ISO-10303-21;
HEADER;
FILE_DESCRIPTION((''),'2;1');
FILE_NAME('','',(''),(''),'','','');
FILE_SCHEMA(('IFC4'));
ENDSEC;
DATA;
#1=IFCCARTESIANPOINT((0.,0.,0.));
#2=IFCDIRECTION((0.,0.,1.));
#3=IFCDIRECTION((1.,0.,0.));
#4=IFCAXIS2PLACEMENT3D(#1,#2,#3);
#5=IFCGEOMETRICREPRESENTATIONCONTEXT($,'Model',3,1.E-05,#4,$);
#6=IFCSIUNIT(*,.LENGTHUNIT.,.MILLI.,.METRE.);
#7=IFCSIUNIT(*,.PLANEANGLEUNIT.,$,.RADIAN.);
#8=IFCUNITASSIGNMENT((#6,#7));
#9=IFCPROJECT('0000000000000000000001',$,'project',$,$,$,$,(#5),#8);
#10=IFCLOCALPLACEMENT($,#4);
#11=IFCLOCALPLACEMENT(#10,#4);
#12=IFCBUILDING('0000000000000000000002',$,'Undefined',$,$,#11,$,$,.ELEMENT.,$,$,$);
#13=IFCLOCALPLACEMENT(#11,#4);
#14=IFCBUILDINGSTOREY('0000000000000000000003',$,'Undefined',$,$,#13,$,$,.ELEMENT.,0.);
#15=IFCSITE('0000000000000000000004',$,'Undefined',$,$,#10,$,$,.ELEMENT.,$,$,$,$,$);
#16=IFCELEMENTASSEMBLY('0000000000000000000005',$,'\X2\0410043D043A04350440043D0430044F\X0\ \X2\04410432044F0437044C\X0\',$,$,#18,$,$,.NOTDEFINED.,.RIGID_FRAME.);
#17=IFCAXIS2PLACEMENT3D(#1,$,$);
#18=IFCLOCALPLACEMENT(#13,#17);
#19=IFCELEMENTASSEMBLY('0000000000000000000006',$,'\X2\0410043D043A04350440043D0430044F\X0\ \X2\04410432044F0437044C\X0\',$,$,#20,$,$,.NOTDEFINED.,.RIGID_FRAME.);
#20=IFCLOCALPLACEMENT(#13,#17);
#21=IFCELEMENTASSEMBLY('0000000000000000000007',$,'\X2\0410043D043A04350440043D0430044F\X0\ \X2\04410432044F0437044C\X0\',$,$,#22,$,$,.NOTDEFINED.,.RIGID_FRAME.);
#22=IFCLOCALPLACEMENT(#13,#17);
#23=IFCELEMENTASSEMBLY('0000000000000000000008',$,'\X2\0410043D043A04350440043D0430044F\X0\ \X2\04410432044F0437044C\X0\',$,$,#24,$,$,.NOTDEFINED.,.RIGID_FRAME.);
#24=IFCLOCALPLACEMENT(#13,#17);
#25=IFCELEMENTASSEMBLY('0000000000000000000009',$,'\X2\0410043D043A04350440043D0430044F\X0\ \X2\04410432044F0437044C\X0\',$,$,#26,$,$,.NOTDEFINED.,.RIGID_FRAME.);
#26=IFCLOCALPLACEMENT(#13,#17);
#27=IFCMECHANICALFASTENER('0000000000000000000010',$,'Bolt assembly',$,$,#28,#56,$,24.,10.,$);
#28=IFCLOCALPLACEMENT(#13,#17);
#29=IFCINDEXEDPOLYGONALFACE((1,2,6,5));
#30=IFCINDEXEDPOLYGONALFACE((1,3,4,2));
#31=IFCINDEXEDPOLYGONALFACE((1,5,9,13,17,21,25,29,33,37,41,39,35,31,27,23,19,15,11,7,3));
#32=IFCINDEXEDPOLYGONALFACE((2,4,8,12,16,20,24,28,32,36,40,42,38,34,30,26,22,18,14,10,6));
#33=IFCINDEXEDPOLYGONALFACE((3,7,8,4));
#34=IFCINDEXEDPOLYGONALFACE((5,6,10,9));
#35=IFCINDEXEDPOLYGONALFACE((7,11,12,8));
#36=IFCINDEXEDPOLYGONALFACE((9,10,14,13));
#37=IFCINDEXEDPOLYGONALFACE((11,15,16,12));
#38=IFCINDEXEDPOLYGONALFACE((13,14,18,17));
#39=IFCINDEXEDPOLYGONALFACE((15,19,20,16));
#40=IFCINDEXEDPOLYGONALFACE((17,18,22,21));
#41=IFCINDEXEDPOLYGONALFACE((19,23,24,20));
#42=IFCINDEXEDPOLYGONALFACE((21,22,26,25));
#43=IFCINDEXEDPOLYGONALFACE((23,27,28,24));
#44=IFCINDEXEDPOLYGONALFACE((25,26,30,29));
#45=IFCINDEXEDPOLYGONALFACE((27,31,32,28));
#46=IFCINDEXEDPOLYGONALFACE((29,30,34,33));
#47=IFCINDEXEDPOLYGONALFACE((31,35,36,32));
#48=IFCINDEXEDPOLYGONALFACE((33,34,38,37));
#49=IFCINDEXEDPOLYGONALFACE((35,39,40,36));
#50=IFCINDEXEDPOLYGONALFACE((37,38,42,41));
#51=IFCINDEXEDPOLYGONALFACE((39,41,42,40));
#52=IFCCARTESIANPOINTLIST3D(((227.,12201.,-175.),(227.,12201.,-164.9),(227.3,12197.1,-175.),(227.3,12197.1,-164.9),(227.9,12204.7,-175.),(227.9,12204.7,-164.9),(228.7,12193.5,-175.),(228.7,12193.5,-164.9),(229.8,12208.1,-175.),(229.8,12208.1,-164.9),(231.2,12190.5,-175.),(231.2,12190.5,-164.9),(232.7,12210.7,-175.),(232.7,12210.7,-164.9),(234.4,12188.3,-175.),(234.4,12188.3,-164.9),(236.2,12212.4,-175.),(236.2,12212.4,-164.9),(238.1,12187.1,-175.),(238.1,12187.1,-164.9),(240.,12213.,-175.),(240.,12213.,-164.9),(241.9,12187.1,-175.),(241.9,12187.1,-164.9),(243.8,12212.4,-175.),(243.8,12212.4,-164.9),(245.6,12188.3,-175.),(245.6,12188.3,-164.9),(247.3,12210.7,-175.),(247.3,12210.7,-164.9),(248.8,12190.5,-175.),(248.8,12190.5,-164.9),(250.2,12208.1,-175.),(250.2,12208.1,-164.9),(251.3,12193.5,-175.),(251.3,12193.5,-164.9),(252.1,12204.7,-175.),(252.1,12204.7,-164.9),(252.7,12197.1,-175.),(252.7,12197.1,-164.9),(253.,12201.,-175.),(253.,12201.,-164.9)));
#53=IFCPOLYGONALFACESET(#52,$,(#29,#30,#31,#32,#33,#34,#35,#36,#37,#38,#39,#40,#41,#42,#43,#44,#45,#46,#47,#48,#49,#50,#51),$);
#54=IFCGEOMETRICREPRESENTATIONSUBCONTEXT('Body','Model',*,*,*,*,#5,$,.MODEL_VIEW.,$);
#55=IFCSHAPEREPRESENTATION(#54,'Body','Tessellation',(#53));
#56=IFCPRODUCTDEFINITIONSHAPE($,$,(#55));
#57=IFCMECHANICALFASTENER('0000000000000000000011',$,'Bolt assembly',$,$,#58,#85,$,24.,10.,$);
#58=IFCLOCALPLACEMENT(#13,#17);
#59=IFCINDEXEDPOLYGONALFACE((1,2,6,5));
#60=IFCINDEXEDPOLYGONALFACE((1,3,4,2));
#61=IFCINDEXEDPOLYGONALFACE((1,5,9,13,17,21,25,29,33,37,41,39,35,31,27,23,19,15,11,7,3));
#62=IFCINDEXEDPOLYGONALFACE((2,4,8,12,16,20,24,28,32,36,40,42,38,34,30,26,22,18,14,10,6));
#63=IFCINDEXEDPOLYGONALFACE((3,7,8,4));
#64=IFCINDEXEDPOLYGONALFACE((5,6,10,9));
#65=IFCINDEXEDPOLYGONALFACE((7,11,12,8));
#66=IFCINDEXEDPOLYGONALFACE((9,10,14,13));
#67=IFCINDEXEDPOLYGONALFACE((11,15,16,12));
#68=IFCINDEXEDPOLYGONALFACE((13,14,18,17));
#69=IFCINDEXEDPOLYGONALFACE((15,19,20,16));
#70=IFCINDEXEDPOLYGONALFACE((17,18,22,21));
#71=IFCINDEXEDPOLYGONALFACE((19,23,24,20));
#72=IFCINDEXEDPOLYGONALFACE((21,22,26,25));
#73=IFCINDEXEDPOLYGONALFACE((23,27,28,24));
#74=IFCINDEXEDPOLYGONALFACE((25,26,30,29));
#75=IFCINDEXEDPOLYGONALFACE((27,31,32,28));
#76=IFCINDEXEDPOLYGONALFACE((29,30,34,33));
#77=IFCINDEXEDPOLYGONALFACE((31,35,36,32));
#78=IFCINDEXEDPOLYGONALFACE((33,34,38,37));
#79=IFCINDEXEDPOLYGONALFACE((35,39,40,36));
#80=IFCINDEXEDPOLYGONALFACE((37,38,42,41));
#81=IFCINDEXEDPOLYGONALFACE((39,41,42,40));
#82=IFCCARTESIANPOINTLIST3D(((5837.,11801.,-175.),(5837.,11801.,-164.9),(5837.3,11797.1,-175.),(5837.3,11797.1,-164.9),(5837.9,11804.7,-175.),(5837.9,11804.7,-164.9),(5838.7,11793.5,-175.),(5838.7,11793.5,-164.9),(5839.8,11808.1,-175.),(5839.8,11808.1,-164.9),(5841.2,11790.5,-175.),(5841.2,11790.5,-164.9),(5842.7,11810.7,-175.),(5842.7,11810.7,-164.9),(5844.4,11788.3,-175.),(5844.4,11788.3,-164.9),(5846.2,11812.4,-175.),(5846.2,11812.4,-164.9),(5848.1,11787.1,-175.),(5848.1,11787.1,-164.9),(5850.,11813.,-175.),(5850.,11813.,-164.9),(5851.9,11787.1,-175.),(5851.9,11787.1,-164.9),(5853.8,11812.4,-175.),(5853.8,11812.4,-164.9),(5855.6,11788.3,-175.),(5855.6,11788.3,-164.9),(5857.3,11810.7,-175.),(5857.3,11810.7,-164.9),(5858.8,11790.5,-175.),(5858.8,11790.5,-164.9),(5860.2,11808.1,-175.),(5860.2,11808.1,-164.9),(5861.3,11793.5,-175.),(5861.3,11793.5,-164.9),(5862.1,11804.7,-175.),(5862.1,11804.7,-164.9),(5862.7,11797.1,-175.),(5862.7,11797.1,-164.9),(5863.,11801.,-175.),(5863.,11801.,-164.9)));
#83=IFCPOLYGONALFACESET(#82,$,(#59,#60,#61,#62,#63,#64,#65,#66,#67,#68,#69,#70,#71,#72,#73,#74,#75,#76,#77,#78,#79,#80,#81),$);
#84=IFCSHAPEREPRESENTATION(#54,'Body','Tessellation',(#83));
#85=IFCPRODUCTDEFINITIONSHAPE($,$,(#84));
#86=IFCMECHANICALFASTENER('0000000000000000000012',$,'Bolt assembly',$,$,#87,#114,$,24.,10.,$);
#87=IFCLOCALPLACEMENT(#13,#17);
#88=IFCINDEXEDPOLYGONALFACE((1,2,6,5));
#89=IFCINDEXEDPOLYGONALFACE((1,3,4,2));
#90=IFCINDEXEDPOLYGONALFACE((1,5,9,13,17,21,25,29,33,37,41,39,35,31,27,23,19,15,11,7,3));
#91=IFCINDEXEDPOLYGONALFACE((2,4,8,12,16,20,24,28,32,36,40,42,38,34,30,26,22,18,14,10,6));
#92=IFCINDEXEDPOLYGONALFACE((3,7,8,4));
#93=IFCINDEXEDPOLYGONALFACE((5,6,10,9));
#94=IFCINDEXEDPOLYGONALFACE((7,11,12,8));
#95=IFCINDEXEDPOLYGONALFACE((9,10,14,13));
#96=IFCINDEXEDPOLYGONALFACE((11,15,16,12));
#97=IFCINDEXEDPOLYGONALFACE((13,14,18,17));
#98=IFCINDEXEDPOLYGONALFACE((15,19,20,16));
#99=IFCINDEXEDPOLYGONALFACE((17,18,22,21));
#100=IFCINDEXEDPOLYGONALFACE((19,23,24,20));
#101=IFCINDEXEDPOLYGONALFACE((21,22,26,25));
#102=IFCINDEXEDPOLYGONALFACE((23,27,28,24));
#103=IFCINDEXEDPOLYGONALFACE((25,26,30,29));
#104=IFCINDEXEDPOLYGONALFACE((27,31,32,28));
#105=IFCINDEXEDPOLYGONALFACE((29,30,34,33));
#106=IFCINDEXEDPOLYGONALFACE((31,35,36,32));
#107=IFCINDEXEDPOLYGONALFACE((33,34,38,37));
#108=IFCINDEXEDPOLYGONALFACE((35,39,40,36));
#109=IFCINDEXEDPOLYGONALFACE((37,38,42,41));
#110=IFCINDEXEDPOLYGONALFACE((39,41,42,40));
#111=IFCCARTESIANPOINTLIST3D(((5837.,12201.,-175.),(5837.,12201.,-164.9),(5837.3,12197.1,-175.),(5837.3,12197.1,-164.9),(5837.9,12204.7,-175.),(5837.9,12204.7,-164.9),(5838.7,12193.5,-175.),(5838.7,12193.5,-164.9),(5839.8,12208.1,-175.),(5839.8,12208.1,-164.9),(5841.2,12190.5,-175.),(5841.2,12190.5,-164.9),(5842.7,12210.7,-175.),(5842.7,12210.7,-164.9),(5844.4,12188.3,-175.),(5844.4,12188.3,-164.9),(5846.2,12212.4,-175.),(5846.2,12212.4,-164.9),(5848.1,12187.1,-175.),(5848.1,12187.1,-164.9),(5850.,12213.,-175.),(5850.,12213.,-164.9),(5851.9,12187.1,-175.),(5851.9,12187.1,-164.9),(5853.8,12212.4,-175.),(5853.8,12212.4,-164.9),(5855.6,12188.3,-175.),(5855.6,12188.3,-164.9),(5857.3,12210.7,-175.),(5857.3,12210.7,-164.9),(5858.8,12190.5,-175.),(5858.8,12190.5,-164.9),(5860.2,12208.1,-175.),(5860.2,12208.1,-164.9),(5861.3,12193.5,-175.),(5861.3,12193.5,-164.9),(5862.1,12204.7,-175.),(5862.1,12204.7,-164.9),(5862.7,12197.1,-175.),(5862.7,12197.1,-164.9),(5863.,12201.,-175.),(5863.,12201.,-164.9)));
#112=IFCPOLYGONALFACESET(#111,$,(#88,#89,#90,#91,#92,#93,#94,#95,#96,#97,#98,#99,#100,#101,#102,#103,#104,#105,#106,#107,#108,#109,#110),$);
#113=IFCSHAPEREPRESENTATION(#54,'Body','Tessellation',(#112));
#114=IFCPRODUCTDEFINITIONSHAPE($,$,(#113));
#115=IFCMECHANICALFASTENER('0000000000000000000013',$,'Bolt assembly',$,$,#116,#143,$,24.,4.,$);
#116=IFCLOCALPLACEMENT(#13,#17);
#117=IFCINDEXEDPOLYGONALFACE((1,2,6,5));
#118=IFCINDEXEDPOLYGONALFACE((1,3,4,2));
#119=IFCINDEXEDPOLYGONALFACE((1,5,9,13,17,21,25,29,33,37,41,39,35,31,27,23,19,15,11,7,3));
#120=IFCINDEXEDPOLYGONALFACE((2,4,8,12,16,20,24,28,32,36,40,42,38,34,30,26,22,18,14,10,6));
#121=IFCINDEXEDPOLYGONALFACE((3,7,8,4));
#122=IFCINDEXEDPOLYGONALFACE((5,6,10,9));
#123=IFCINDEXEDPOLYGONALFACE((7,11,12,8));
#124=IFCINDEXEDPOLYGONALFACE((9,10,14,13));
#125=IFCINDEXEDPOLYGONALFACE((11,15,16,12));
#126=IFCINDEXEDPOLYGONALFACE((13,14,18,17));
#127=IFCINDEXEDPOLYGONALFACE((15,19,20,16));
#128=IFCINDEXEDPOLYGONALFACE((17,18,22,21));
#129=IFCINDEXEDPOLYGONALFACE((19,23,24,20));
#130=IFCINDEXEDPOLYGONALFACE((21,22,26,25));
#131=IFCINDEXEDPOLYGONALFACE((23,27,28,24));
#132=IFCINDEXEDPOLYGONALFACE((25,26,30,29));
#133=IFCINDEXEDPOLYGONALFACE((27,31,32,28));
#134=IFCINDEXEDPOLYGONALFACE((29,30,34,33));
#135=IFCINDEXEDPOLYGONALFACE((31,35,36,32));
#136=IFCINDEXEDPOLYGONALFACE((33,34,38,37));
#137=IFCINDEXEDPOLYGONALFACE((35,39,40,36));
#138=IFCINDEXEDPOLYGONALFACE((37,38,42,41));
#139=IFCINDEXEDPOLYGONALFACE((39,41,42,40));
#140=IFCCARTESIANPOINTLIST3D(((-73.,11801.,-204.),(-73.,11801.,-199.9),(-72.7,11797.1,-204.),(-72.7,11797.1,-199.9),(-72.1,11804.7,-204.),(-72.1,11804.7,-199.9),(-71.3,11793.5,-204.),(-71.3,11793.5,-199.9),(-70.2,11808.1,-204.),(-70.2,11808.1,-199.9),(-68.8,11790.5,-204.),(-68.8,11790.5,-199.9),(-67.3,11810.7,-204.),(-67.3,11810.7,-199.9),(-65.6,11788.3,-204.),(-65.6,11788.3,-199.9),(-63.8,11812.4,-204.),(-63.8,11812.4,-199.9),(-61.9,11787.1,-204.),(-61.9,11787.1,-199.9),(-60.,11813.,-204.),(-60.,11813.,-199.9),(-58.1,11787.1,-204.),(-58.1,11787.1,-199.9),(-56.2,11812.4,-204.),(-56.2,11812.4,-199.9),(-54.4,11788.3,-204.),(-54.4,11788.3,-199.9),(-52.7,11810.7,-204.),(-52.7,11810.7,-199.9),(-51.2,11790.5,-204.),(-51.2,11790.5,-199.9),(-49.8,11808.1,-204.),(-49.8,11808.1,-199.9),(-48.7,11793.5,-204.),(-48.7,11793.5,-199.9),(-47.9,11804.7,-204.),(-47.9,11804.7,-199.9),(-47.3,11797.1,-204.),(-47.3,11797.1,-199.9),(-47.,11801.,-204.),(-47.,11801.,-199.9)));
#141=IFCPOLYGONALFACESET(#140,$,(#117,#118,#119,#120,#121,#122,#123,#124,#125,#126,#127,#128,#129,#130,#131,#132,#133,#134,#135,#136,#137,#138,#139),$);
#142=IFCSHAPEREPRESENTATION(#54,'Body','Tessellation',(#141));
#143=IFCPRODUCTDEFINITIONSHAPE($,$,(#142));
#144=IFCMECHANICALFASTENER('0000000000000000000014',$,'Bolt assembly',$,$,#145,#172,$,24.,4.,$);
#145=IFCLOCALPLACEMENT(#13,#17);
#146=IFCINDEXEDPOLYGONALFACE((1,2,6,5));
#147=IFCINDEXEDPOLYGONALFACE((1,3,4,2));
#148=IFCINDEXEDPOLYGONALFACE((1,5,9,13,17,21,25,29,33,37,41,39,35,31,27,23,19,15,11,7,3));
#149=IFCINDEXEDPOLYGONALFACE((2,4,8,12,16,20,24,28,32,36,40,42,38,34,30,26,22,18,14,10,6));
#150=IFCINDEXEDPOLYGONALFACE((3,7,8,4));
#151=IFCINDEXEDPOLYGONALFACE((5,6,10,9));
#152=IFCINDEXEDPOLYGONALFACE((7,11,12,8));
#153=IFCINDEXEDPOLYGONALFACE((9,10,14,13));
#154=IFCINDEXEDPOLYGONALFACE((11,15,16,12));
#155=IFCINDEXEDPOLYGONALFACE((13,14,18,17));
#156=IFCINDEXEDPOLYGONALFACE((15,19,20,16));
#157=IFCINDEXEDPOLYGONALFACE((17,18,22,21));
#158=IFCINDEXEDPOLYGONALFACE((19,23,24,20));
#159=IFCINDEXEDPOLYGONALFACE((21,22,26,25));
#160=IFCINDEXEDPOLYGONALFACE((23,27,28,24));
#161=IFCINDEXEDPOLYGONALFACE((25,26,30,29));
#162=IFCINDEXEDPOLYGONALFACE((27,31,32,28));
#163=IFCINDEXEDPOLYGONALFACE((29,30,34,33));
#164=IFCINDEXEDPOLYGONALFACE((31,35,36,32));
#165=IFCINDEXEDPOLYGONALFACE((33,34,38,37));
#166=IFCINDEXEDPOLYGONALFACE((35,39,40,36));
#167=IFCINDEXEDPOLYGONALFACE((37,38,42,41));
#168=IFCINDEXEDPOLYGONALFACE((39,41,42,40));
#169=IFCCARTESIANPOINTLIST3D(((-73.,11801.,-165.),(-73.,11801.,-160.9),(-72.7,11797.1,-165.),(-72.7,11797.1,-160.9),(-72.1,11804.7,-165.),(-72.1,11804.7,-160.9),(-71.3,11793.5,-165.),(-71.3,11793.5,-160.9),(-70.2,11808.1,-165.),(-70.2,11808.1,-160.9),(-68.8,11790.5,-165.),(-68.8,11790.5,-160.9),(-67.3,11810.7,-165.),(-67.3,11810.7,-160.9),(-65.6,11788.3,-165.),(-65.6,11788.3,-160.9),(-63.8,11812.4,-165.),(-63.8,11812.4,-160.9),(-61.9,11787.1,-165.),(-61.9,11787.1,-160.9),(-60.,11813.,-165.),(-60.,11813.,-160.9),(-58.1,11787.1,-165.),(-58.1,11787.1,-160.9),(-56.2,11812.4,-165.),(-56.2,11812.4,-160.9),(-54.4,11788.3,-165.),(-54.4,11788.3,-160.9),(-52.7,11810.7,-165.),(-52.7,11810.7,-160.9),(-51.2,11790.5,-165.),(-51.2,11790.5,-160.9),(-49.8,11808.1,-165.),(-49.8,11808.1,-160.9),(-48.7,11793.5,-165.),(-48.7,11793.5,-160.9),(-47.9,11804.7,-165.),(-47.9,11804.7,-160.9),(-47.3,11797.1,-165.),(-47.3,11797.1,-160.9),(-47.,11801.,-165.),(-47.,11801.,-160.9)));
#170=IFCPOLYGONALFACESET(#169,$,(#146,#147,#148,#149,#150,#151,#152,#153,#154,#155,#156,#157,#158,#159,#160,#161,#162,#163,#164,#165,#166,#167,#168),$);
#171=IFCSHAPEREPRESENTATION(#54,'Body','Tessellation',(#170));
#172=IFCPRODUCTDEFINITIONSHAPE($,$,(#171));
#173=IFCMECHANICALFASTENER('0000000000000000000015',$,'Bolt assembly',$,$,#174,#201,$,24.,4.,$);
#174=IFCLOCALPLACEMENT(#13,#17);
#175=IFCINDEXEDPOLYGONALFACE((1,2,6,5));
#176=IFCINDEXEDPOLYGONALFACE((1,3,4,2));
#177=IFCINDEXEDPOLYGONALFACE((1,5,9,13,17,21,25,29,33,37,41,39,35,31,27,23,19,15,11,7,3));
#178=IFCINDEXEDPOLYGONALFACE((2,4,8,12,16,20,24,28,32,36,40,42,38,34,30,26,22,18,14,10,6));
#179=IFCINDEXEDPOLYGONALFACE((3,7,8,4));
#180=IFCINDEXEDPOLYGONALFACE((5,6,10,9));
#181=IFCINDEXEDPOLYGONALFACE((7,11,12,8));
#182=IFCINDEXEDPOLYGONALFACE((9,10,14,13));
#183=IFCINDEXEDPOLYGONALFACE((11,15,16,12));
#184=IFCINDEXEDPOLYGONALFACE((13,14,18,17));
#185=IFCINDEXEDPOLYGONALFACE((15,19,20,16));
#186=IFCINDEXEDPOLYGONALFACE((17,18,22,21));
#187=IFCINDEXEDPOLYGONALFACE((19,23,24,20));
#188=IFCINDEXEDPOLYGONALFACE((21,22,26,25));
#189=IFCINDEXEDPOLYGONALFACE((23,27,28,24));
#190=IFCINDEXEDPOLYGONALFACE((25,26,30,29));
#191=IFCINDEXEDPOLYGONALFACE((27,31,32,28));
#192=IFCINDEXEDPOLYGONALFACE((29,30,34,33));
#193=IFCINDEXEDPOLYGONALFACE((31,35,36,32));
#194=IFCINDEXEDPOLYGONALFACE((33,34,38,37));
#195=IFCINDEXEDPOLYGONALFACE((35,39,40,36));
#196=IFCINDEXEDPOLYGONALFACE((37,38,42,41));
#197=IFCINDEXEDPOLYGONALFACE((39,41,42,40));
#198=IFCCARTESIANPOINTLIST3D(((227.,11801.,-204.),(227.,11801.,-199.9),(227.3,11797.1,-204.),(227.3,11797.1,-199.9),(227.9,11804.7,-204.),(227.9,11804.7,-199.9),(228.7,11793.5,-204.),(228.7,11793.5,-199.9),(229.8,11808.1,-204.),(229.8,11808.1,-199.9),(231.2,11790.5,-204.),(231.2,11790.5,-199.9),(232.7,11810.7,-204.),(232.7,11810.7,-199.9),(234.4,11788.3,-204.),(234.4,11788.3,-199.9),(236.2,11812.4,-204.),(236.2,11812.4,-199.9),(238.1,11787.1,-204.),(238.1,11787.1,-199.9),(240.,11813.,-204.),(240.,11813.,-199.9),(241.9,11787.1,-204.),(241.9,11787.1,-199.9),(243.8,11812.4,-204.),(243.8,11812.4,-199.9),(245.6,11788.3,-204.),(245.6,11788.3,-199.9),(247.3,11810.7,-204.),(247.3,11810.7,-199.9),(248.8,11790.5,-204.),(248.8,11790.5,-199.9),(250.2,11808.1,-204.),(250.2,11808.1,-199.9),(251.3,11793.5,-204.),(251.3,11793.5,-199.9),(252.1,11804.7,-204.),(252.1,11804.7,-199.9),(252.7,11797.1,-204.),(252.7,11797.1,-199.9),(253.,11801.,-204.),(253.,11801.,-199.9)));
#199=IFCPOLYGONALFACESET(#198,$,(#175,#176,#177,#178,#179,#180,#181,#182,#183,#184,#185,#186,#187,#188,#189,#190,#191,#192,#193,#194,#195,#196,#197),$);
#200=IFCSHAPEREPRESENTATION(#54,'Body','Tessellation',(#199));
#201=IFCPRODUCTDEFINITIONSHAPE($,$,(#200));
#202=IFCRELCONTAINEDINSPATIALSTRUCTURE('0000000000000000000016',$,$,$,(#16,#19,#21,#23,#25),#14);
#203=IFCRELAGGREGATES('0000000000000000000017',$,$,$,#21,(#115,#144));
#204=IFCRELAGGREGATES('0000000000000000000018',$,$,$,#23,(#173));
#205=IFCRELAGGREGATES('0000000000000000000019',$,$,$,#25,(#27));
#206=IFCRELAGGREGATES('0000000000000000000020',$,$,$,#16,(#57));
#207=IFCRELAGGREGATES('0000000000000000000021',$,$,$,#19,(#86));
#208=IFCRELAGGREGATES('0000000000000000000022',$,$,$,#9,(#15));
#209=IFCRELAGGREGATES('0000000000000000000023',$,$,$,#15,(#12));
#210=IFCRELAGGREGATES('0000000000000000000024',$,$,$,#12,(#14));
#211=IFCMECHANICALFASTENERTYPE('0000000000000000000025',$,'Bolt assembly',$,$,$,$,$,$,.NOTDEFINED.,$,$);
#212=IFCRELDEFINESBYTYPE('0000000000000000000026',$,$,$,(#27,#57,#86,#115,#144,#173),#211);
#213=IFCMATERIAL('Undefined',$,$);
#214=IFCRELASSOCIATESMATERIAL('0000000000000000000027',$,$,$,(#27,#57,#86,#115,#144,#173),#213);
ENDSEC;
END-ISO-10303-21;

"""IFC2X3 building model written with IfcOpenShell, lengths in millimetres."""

from ifc_helpers import new_model, si_unit, frame, origin_with_axes, origin_2d_with_axis, place, context, subcontext, project, spatial, circle, extrude, source, transform, mapped, material, type_object, element, aggregate, save


model = new_model("IFC2X3")

# Units and contexts
model_context = context("Model", 3, precision=1e-05, world=origin_with_axes())
body_context = subcontext(model_context, "Body", "Model", "MODEL_VIEW")
ifc_project = project(units=[si_unit("LENGTHUNIT", "METRE", prefix="MILLI"), si_unit("PLANEANGLEUNIT", "RADIAN")], contexts=[model_context])

# Site, building, storey
site_placement = place(None, origin_with_axes())
site = spatial("IfcSite", under=ifc_project, at=site_placement, Name="Undefined", CompositionType="ELEMENT")
building_placement = place(site_placement, origin_with_axes())
building = spatial("IfcBuilding", under=site, at=building_placement, Name="Undefined", CompositionType="ELEMENT")
storey_placement = place(building_placement, origin_with_axes())
storey = spatial("IfcBuildingStorey", under=building, at=storey_placement, Name="Undefined", CompositionType="ELEMENT", Elevation=0.0)

# Element assemblies
assembly_1_placement = place(storey_placement, origin_with_axes())
assembly_1 = element("IfcElementAssembly", 1, at=assembly_1_placement, inside=storey, Name="Анкерная связь", AssemblyPlace="NOTDEFINED", PredefinedType="RIGID_FRAME")
assembly_2_placement = place(storey_placement, origin_with_axes())
assembly_2 = element("IfcElementAssembly", 2, at=assembly_2_placement, inside=storey, Name="Анкерная связь", AssemblyPlace="NOTDEFINED", PredefinedType="RIGID_FRAME")

# Element assemblies
assembly_3_placement = place(storey_placement, origin_with_axes())
assembly_3 = element("IfcElementAssembly", 3, at=assembly_3_placement, inside=storey, Name="Анкерная связь", AssemblyPlace="NOTDEFINED", PredefinedType="RIGID_FRAME")
assembly_4_placement = place(storey_placement, origin_with_axes())
assembly_4 = element("IfcElementAssembly", 4, at=assembly_4_placement, inside=storey, Name="Анкерная связь", AssemblyPlace="NOTDEFINED", PredefinedType="RIGID_FRAME")
assembly_5_placement = place(storey_placement, origin_with_axes())
assembly_5 = element("IfcElementAssembly", 5, at=assembly_5_placement, inside=storey, Name="Анкерная связь", AssemblyPlace="NOTDEFINED", PredefinedType="RIGID_FRAME")

# Mechanical fasteners
ifc_material_1 = material(Name="Undefined")
mechanical_fastener_type = type_object("IfcMechanicalFastenerType", Name="Bolt assembly")
shared_shape_1 = source(origin_with_axes(), body_context, "Body", "SweptSolid", [
    extrude(circle(Radius=13.0, at=origin_2d_with_axis()), frame((0.0, 0.0, 0.0), z_axis=(0.0, 1.0, 0.0), x_axis=(1.0, 0.0, 0.0)), (0.0, 0.0, 1.0), 10.1),
])
mechanical_fastener_1_placement = place(assembly_5_placement, frame((240.0, 12200.0, -175.0), z_axis=(1.0, 0.0, 0.0), x_axis=(0.0, 1.0, 0.0)))
mechanical_fastener_1 = element("IfcMechanicalFastener", 6, at=mechanical_fastener_1_placement, type_object=mechanical_fastener_type, material=ifc_material_1, Name="Bolt assembly", NominalDiameter=24.0, NominalLength=10.0, context=body_context, shape_type="MappedRepresentation", body=[
    mapped(shared_shape_1, transform((0.0, 0.0, 0.0))),
])
mechanical_fastener_2_placement = place(assembly_1_placement, frame((5850.0, 11800.0, -175.0), z_axis=(1.0, 0.0, 0.0), x_axis=(0.0, 1.0, 0.0)))
mechanical_fastener_2 = element("IfcMechanicalFastener", 7, at=mechanical_fastener_2_placement, type_object=mechanical_fastener_type, material=ifc_material_1, Name="Bolt assembly", NominalDiameter=24.0, NominalLength=10.0, context=body_context, shape_type="MappedRepresentation", body=[
    mapped(shared_shape_1, transform((0.0, 0.0, 0.0))),
])
mechanical_fastener_3_placement = place(assembly_2_placement, frame((5850.0, 12200.0, -175.0), z_axis=(1.0, 0.0, 0.0), x_axis=(0.0, 1.0, 0.0)))
mechanical_fastener_3 = element("IfcMechanicalFastener", 8, at=mechanical_fastener_3_placement, type_object=mechanical_fastener_type, material=ifc_material_1, Name="Bolt assembly", NominalDiameter=24.0, NominalLength=10.0, context=body_context, shape_type="MappedRepresentation", body=[
    mapped(shared_shape_1, transform((0.0, 0.0, 0.0))),
])
shared_shape_2 = source(origin_with_axes(), body_context, "Body", "SweptSolid", [
    extrude(circle(Radius=13.0, at=origin_2d_with_axis()), frame((0.0, -4.0, 0.0), z_axis=(0.0, 1.0, 0.0), x_axis=(1.0, 0.0, 0.0)), (0.0, 0.0, 1.0), 4.1),
])
mechanical_fastener_4_placement = place(assembly_3_placement, frame((-60.0, 11800.0, -200.0), z_axis=(1.0, 0.0, 0.0), x_axis=(0.0, 1.0, 0.0)))
mechanical_fastener_4 = element("IfcMechanicalFastener", 9, at=mechanical_fastener_4_placement, type_object=mechanical_fastener_type, material=ifc_material_1, Name="Bolt assembly", NominalDiameter=24.0, NominalLength=4.0, context=body_context, shape_type="MappedRepresentation", body=[
    mapped(shared_shape_2, transform((0.0, 0.0, 0.0))),
])
mechanical_fastener_5_placement = place(assembly_3_placement, frame((-60.0, 11800.0, -161.0), z_axis=(1.0, 0.0, 0.0), x_axis=(0.0, 1.0, 0.0)))
mechanical_fastener_5 = element("IfcMechanicalFastener", 10, at=mechanical_fastener_5_placement, type_object=mechanical_fastener_type, material=ifc_material_1, Name="Bolt assembly", NominalDiameter=24.0, NominalLength=4.0, context=body_context, shape_type="MappedRepresentation", body=[
    mapped(shared_shape_2, transform((0.0, 0.0, 0.0))),
])
aggregate(assembly_3, [mechanical_fastener_4, mechanical_fastener_5])
mechanical_fastener_6_placement = place(assembly_4_placement, frame((240.0, 11800.0, -200.0), z_axis=(1.0, 0.0, 0.0), x_axis=(0.0, 1.0, 0.0)))
mechanical_fastener_6 = element("IfcMechanicalFastener", 11, at=mechanical_fastener_6_placement, type_object=mechanical_fastener_type, material=ifc_material_1, Name="Bolt assembly", NominalDiameter=24.0, NominalLength=4.0, context=body_context, shape_type="MappedRepresentation", body=[
    mapped(shared_shape_2, transform((0.0, 0.0, 0.0))),
])
aggregate(assembly_4, [mechanical_fastener_6])
aggregate(assembly_5, [mechanical_fastener_1])
aggregate(assembly_1, [mechanical_fastener_2])
aggregate(assembly_2, [mechanical_fastener_3])

save(model, "model.ifc")
